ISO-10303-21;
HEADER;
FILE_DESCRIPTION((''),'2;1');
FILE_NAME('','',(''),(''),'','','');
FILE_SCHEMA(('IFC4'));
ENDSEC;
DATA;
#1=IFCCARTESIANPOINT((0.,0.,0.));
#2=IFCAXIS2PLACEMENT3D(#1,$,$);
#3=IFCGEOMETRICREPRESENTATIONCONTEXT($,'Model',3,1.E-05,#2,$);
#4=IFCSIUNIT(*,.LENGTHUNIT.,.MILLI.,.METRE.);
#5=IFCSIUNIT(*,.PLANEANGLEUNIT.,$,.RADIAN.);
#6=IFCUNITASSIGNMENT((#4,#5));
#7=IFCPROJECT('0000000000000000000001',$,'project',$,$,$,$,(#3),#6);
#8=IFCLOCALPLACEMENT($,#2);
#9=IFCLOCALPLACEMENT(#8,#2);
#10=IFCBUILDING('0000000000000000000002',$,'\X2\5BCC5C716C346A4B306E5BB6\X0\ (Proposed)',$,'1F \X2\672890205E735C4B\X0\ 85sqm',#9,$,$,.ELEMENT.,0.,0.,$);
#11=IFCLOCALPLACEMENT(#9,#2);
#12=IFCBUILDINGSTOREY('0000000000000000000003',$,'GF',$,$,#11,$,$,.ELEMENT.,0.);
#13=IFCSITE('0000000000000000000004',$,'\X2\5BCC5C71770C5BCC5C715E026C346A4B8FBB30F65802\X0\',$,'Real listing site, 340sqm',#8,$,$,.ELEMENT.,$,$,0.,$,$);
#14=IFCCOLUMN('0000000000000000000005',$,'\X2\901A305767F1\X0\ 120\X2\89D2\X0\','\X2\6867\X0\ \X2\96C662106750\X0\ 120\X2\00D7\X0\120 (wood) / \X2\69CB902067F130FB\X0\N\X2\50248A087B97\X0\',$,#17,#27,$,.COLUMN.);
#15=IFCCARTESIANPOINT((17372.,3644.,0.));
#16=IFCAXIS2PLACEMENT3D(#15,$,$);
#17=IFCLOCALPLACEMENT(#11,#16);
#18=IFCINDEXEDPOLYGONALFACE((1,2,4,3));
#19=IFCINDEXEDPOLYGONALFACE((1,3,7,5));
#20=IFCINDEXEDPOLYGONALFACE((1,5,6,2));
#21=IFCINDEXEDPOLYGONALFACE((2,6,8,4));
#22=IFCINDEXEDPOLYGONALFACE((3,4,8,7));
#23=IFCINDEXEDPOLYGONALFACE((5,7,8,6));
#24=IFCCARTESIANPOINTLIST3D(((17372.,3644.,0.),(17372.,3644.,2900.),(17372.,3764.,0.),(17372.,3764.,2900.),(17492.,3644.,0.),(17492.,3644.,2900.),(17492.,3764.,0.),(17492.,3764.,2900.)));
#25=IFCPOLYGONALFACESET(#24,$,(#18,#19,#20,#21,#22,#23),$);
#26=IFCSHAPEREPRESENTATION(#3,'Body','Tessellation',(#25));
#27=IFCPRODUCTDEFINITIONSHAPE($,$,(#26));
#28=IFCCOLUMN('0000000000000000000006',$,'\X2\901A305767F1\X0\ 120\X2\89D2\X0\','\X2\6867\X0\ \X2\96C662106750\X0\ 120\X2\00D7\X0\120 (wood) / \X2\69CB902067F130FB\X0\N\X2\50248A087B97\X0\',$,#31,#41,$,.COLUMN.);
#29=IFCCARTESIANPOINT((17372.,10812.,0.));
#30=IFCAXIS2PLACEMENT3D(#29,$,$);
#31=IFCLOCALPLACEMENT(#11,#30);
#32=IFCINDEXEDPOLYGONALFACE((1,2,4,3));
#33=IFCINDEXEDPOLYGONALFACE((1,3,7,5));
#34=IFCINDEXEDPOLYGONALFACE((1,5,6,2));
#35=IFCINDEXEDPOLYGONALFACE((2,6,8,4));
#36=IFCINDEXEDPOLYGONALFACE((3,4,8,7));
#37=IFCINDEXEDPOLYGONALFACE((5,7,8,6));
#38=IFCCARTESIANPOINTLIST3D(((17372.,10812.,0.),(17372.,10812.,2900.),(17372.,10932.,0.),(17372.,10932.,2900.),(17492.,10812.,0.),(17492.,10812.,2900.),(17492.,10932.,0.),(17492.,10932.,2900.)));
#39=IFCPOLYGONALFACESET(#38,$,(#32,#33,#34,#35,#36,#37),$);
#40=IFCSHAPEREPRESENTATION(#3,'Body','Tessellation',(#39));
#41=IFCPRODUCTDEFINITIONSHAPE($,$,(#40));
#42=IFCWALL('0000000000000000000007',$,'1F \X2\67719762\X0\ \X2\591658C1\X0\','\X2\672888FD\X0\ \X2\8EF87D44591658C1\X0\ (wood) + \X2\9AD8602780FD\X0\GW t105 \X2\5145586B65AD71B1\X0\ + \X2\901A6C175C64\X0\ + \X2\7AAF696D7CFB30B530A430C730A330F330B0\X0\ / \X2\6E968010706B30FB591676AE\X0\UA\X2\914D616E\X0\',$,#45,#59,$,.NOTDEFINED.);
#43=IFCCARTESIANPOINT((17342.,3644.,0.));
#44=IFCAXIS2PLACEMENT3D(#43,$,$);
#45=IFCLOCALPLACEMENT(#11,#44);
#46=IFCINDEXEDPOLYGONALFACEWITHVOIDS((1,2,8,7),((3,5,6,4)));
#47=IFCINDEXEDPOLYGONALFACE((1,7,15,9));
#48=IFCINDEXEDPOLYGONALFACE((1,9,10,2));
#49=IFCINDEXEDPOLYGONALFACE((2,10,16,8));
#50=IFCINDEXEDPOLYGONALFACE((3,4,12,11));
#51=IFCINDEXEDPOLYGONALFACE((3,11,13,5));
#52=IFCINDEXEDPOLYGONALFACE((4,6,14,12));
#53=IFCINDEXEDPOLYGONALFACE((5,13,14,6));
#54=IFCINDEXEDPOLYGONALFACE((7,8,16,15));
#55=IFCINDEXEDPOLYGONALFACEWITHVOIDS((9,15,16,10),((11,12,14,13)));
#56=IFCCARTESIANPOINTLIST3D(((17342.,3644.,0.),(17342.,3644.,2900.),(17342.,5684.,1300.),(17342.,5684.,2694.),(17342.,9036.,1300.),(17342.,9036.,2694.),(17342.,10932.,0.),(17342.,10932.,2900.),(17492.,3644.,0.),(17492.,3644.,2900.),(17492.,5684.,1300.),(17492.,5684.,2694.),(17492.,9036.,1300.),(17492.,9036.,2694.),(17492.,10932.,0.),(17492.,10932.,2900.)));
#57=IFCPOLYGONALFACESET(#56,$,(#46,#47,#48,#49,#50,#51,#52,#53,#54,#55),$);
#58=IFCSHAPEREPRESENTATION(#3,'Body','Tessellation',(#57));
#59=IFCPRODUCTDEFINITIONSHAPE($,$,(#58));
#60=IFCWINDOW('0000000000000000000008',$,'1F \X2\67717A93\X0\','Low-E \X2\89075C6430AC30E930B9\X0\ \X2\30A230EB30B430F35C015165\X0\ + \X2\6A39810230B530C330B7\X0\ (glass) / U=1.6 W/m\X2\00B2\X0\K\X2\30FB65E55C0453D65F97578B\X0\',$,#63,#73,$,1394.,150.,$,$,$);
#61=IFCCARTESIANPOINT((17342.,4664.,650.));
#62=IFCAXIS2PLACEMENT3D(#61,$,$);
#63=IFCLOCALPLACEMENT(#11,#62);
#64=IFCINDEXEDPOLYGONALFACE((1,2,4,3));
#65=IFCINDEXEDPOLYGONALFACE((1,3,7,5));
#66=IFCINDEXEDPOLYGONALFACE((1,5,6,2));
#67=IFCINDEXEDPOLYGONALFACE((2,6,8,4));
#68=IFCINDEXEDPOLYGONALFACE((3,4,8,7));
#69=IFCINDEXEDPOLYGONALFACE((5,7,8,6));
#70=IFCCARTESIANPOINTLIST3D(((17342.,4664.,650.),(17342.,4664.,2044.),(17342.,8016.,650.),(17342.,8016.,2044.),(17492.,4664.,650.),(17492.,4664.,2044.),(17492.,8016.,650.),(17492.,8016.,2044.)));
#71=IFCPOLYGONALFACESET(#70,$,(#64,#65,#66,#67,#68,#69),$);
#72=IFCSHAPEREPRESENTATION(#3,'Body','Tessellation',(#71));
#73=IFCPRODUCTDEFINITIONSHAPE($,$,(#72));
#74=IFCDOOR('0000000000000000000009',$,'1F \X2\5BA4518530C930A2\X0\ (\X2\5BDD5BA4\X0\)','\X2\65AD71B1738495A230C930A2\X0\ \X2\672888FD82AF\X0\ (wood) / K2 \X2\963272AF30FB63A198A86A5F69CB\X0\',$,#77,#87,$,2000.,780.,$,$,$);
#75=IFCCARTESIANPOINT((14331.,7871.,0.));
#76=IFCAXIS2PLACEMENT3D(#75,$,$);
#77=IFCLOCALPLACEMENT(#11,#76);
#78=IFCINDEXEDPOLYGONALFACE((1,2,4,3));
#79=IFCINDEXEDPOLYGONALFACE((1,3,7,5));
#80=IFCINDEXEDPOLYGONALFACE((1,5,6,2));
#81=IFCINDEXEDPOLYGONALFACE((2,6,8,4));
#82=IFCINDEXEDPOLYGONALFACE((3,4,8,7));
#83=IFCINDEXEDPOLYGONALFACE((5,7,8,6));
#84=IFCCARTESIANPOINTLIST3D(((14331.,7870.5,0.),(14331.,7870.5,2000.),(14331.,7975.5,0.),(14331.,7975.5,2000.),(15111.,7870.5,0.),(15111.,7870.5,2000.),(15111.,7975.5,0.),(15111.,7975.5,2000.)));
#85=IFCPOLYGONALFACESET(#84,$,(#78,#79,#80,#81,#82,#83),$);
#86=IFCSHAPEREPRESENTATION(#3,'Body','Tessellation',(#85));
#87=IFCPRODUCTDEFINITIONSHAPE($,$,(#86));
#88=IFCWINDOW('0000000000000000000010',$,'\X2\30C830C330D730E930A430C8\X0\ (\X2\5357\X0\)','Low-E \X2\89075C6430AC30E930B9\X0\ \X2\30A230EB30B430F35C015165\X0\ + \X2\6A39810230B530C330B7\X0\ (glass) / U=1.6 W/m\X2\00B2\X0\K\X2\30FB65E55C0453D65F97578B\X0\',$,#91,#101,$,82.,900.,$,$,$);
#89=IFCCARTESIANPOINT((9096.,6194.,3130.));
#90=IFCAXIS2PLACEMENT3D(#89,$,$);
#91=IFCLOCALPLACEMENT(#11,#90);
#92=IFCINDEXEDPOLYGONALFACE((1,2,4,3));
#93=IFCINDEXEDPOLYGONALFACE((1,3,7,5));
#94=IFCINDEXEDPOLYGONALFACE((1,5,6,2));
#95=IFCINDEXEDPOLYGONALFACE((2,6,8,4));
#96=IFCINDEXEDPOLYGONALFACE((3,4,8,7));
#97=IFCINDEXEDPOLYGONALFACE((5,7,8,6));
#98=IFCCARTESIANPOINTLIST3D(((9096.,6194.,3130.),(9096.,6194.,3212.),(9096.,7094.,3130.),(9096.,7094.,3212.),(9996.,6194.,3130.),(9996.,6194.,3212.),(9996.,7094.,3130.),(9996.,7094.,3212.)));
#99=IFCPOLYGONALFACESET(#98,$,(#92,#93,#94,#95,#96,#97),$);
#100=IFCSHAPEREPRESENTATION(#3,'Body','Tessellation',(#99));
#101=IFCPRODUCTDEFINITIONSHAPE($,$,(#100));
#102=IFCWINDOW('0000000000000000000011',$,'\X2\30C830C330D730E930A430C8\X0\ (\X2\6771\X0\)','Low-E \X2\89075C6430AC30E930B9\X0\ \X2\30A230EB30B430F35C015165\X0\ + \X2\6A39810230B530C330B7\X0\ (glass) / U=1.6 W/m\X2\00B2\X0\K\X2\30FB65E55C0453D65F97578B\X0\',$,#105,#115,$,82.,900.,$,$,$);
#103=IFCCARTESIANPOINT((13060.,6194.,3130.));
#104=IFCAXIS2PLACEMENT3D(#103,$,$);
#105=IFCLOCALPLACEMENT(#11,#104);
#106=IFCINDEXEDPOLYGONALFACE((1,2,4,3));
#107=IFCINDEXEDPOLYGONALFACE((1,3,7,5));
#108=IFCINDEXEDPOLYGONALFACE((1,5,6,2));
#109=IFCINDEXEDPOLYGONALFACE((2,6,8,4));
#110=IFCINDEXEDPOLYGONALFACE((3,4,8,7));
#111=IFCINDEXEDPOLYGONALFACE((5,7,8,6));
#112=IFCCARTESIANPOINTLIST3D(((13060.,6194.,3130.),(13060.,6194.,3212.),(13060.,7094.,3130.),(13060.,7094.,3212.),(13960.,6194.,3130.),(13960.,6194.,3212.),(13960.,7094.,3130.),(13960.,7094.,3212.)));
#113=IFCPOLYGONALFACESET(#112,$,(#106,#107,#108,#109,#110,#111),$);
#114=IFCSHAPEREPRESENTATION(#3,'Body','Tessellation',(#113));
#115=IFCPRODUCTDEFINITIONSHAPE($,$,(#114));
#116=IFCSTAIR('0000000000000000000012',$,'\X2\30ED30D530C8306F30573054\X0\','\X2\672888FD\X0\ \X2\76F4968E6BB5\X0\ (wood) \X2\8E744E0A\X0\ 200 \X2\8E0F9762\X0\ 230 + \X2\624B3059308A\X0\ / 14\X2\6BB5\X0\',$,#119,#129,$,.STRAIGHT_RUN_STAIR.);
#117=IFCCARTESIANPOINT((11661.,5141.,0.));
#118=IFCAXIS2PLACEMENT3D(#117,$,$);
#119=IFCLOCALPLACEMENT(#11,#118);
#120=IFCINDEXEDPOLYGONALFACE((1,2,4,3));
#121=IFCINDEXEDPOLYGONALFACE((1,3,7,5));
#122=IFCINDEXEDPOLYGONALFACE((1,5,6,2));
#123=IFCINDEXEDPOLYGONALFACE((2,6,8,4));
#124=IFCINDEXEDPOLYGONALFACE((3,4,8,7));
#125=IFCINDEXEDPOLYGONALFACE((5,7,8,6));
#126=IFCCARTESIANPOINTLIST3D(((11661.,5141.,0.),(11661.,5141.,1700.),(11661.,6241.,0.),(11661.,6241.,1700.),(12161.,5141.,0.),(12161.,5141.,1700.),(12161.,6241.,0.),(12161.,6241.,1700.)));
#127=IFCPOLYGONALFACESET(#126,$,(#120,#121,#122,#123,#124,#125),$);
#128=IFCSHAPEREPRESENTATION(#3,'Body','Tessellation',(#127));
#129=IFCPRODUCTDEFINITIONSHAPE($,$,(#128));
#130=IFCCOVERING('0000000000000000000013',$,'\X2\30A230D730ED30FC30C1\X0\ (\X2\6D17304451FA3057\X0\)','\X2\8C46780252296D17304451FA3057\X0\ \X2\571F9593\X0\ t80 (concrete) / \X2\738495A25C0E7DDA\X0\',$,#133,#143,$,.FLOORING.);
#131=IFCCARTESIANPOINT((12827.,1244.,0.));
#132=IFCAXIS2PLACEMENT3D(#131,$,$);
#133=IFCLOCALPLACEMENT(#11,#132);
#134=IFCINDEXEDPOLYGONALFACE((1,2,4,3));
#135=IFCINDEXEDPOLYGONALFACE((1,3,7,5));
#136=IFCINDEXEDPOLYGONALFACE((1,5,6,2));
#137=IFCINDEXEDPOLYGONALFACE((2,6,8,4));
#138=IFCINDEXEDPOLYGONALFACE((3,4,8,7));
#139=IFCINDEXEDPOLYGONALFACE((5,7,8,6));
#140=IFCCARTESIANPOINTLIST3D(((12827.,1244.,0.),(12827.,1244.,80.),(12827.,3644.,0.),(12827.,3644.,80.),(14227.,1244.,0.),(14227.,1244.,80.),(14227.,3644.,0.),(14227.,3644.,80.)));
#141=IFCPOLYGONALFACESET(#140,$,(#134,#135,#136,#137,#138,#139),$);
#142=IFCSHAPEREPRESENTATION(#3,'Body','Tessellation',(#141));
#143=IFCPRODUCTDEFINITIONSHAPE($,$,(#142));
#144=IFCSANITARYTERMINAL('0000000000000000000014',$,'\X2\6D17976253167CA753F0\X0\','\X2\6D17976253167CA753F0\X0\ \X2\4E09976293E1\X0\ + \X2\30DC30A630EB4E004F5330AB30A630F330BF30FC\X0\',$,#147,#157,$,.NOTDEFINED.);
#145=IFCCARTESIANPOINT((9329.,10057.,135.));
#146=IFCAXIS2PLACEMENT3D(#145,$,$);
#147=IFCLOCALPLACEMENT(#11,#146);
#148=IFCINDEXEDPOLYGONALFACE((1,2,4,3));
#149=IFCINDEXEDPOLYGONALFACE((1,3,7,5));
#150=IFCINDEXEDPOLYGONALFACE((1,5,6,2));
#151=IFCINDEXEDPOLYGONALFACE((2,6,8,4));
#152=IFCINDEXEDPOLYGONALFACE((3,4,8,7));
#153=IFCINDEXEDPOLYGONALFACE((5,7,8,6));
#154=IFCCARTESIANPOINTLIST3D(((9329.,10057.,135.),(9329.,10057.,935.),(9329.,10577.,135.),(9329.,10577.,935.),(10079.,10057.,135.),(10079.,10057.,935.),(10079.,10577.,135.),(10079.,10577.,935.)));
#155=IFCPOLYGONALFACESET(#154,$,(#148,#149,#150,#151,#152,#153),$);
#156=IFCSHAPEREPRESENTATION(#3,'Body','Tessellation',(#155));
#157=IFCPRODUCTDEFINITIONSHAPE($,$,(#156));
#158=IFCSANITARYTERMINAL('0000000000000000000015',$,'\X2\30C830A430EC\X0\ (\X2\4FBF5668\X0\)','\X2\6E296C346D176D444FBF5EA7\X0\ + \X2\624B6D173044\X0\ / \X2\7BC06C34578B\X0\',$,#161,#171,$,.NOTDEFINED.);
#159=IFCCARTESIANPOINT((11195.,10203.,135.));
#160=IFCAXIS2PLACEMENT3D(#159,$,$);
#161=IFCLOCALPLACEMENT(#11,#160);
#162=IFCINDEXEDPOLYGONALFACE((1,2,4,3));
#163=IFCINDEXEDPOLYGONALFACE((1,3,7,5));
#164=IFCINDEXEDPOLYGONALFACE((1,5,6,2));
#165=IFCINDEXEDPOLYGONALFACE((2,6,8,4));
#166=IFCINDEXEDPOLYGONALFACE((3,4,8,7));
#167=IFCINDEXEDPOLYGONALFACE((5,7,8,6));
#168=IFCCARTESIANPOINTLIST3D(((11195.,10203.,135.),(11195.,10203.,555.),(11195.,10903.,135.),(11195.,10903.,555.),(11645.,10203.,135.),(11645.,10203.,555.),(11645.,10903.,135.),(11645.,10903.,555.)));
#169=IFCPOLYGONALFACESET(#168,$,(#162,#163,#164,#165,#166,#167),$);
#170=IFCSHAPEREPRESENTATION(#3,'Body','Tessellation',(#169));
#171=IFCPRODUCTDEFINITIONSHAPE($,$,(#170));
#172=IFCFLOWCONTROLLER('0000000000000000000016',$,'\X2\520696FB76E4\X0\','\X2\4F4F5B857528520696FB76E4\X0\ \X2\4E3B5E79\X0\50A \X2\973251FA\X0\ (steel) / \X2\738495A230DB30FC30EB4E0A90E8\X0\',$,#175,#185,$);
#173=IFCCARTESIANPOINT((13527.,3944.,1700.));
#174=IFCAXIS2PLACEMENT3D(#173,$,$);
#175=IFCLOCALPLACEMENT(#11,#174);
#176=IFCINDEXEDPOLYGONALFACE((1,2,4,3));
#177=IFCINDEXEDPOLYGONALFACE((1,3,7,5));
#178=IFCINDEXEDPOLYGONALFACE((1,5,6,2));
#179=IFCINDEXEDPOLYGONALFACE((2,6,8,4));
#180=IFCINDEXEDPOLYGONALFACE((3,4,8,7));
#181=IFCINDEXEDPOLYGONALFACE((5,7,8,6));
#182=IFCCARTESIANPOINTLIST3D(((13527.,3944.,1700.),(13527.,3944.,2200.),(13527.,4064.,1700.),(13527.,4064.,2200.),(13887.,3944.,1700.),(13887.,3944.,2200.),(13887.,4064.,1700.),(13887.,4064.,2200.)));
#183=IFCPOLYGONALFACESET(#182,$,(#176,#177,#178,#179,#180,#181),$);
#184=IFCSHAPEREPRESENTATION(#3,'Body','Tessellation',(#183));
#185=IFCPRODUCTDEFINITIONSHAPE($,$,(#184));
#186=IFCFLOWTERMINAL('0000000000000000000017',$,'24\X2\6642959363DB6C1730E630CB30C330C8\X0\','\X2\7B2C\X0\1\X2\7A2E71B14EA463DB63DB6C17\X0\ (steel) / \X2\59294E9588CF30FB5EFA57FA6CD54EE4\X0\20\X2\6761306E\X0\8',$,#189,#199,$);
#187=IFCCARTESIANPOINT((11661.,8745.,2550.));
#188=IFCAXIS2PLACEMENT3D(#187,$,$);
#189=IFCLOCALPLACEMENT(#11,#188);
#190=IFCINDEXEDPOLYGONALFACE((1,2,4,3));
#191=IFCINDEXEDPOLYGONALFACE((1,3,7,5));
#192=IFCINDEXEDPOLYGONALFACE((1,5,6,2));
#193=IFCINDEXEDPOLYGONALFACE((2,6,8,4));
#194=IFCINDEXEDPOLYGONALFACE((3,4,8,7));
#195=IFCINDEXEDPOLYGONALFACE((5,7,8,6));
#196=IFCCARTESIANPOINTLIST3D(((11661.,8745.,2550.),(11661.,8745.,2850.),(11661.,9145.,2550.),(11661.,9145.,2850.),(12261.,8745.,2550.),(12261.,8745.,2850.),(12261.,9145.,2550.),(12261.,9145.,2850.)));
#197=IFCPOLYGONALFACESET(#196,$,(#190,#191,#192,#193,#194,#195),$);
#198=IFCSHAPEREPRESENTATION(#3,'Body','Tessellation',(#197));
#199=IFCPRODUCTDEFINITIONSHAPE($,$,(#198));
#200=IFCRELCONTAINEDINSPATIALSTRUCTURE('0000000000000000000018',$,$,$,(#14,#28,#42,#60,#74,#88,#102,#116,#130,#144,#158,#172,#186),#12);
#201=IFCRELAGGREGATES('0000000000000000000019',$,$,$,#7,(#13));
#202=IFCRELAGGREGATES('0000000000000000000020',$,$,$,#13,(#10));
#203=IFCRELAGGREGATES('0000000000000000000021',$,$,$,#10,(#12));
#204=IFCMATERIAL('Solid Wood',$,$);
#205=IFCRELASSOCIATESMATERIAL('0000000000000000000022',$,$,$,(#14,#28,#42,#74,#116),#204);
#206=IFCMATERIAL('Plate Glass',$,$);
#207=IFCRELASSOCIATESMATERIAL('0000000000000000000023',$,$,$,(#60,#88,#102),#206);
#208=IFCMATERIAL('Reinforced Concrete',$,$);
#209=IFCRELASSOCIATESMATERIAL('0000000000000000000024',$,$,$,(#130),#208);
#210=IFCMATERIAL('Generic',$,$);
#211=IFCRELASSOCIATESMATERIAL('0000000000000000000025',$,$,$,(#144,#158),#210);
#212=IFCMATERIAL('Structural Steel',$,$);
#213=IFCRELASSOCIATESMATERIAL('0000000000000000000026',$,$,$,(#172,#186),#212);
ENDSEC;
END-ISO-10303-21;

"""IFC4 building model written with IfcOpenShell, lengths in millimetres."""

from ifc_helpers import new_model, si_unit, frame, frame_2d, origin, place, context, project, spatial, rectangle, extrude, material, element, fill, save


model = new_model("IFC4")

# Units and contexts
model_context = context("Model", 3, precision=1e-05, world=origin())
ifc_project = project(units=[si_unit("LENGTHUNIT", "METRE", prefix="MILLI"), si_unit("PLANEANGLEUNIT", "RADIAN")], contexts=[model_context])

# Site, building, storey
site_placement = place(None, origin())
site = spatial("IfcSite", under=ifc_project, at=site_placement, Name="富山県富山市水橋辻ヶ堂", ObjectType="Real listing site, 340sqm", CompositionType="ELEMENT", RefElevation=0.0)
building_placement = place(site_placement, origin())
building = spatial("IfcBuilding", under=site, at=building_placement, Name="富山水橋の家 (Proposed)", ObjectType="1F 木造平屋 85sqm", CompositionType="ELEMENT", ElevationOfRefHeight=0.0, ElevationOfTerrain=0.0)
storey_placement = place(building_placement, origin())
storey = spatial("IfcBuildingStorey", under=building, at=storey_placement, Name="GF", CompositionType="ELEMENT", Elevation=0.0)

# Columns
ifc_material_1 = material(Name="Solid Wood")
column_1_placement = place(storey_placement, frame((17372.0, 3644.0, 0.0)))
element("IfcColumn", 1, at=column_1_placement, inside=storey, material=ifc_material_1, Name="通し柱 120角", Description="桧 集成材 120×120 (wood) / 構造柱・N値計算", PredefinedType="COLUMN", context=model_context, shape_type="SweptSolid", body=[
    extrude(rectangle(XDim=120.0, YDim=120.0, at=frame_2d((60.0, 60.0))), frame((17372.0, 3644.0, 0.0)), (0.0, 0.0, 1.0), 2900.0),
])
column_2_placement = place(storey_placement, frame((17372.0, 10812.0, 0.0)))
element("IfcColumn", 2, at=column_2_placement, inside=storey, material=ifc_material_1, Name="通し柱 120角", Description="桧 集成材 120×120 (wood) / 構造柱・N値計算", PredefinedType="COLUMN", context=model_context, shape_type="SweptSolid", body=[
    extrude(rectangle(XDim=120.0, YDim=120.0, at=frame_2d((60.0, 60.0))), frame((17372.0, 10812.0, 0.0)), (0.0, 0.0, 1.0), 2900.0),
])

# Wall, opening, window
wall_1_placement = place(storey_placement, frame((17342.0, 3644.0, 0.0)))
wall_1 = element("IfcWall", 3, at=wall_1_placement, inside=storey, material=ifc_material_1, Name="1F 東面 外壁", Description="木製 軸組外壁 (wood) + 高性能GW t105 充填断熱 + 通気層 + 窯業系サイディング / 準耐火・外皮UA配慮", PredefinedType="NOTDEFINED", context=model_context, shape_type="SweptSolid", body=[
    extrude(rectangle(XDim=150.0, YDim=7288.0, at=frame_2d((75.0, 3644.0))), frame((17342.0, 3644.0, 0.0)), (0.0, 0.0, 1.0), 2900.0),
])
opening_placement = place(storey_placement, frame((17342.0, 4664.0, 650.0)))
opening = element("IfcOpeningElement", 4, at=opening_placement, cuts=wall_1, PredefinedType="NOTDEFINED", context=model_context, shape_type="SweptSolid", body=[
    extrude(rectangle(XDim=150.0, YDim=3352.0, at=frame_2d((75.0, 1676.0))), frame((17342.0, 4664.0, 650.0)), (0.0, 0.0, 1.0), 1394.0),
])
ifc_material_2 = material(Name="Plate Glass")
window_1_placement = place(storey_placement, frame((17342.0, 4664.0, 650.0)))
window_1 = element("IfcWindow", 5, at=window_1_placement, inside=storey, material=ifc_material_2, Name="1F 東窓", Description="Low-E 複層ガラス アルゴン封入 + 樹脂サッシ (glass) / U=1.6 W/m²K・日射取得型", OverallHeight=1394.0, OverallWidth=150.0, context=model_context, shape_type="SweptSolid", body=[
    extrude(rectangle(XDim=150.0, YDim=3352.0, at=frame_2d((75.0, 1676.0))), frame((17342.0, 4664.0, 650.0)), (0.0, 0.0, 1.0), 1394.0),
])
fill(opening, window_1)

# Door
door_placement = place(storey_placement, frame((14331.0, 7871.0, 0.0)))
element("IfcDoor", 6, at=door_placement, inside=storey, material=ifc_material_1, Name="1F 室内ドア (寝室)", Description="断熱玄関ドア 木製芯 (wood) / K2 防犯・採風機構", OverallHeight=2000.0, OverallWidth=780.0, context=model_context, shape_type="SweptSolid", body=[
    extrude(rectangle(XDim=780.0, YDim=105.0, at=frame_2d((390.0, 52.0))), frame((14331.0, 7871.0, 0.0)), (0.0, 0.0, 1.0), 2000.0),
])

# Windows
window_2_placement = place(storey_placement, frame((9096.0, 6194.0, 3130.0)))
element("IfcWindow", 7, at=window_2_placement, inside=storey, material=ifc_material_2, Name="トップライト (南)", Description="Low-E 複層ガラス アルゴン封入 + 樹脂サッシ (glass) / U=1.6 W/m²K・日射取得型", OverallHeight=82.0, OverallWidth=900.0, context=model_context, shape_type="SweptSolid", body=[
    extrude(rectangle(XDim=900.0, YDim=900.0, at=frame_2d((450.0, 450.0))), frame((9096.0, 6194.0, 3130.0)), (0.0, 0.0, 1.0), 82.0),
])
window_3_placement = place(storey_placement, frame((13060.0, 6194.0, 3130.0)))
element("IfcWindow", 8, at=window_3_placement, inside=storey, material=ifc_material_2, Name="トップライト (東)", Description="Low-E 複層ガラス アルゴン封入 + 樹脂サッシ (glass) / U=1.6 W/m²K・日射取得型", OverallHeight=82.0, OverallWidth=900.0, context=model_context, shape_type="SweptSolid", body=[
    extrude(rectangle(XDim=900.0, YDim=900.0, at=frame_2d((450.0, 450.0))), frame((13060.0, 6194.0, 3130.0)), (0.0, 0.0, 1.0), 82.0),
])

# Stair
stair_placement = place(storey_placement, frame((11661.0, 5141.0, 0.0)))
element("IfcStair", 9, at=stair_placement, inside=storey, material=ifc_material_1, Name="ロフトはしご", Description="木製 直階段 (wood) 蹴上 200 踏面 230 + 手すり / 14段", PredefinedType="STRAIGHT_RUN_STAIR", context=model_context, shape_type="SweptSolid", body=[
    extrude(rectangle(XDim=500.0, YDim=1100.0, at=frame_2d((250.0, 550.0))), frame((11661.0, 5141.0, 0.0)), (0.0, 0.0, 1.0), 1700.0),
])

# Covering
ifc_material_3 = material(Name="Reinforced Concrete")
covering_placement = place(storey_placement, frame((12827.0, 1244.0, 0.0)))
element("IfcCovering", 10, at=covering_placement, inside=storey, material=ifc_material_3, Name="アプローチ (洗い出し)", Description="豆砂利洗い出し 土間 t80 (concrete) / 玄関導線", PredefinedType="FLOORING", context=model_context, shape_type="SweptSolid", body=[
    extrude(rectangle(XDim=1400.0, YDim=2400.0, at=frame_2d((700.0, 1200.0))), frame((12827.0, 1244.0, 0.0)), (0.0, 0.0, 1.0), 80.0),
])

# Sanitary terminals
ifc_material_4 = material(Name="Generic")
sanitary_terminal_1_placement = place(storey_placement, frame((9329.0, 10057.0, 135.0)))
element("IfcSanitaryTerminal", 11, at=sanitary_terminal_1_placement, inside=storey, material=ifc_material_4, Name="洗面化粧台", Description="洗面化粧台 三面鏡 + ボウル一体カウンター", PredefinedType="NOTDEFINED", context=model_context, shape_type="SweptSolid", body=[
    extrude(rectangle(XDim=750.0, YDim=520.0, at=frame_2d((375.0, 260.0))), frame((9329.0, 10057.0, 135.0)), (0.0, 0.0, 1.0), 800.0),
])
sanitary_terminal_2_placement = place(storey_placement, frame((11195.0, 10203.0, 135.0)))
element("IfcSanitaryTerminal", 12, at=sanitary_terminal_2_placement, inside=storey, material=ifc_material_4, Name="トイレ (便器)", Description="温水洗浄便座 + 手洗い / 節水型", PredefinedType="NOTDEFINED", context=model_context, shape_type="SweptSolid", body=[
    extrude(rectangle(XDim=450.0, YDim=700.0, at=frame_2d((225.0, 350.0))), frame((11195.0, 10203.0, 135.0)), (0.0, 0.0, 1.0), 420.0),
])

# Flow controller
ifc_material_5 = material(Name="Structural Steel")
flow_controller_placement = place(storey_placement, frame((13527.0, 3944.0, 1700.0)))
element("IfcFlowController", 13, at=flow_controller_placement, inside=storey, material=ifc_material_5, Name="分電盤", Description="住宅用分電盤 主幹50A 露出 (steel) / 玄関ホール上部", context=model_context, shape_type="SweptSolid", body=[
    extrude(rectangle(XDim=360.0, YDim=120.0, at=frame_2d((180.0, 60.0))), frame((13527.0, 3944.0, 1700.0)), (0.0, 0.0, 1.0), 500.0),
])

# Flow terminal
flow_terminal_1_placement = place(storey_placement, frame((11661.0, 8745.0, 2550.0)))
element("IfcFlowTerminal", 14, at=flow_terminal_1_placement, inside=storey, material=ifc_material_5, Name="24時間換気ユニット", Description="第1種熱交換換気 (steel) / 天井裏・建基法令20条の8", context=model_context, shape_type="SweptSolid", body=[
    extrude(rectangle(XDim=600.0, YDim=400.0, at=frame_2d((300.0, 200.0))), frame((11661.0, 8745.0, 2550.0)), (0.0, 0.0, 1.0), 300.0),
])

save(model, "model.ifc")
